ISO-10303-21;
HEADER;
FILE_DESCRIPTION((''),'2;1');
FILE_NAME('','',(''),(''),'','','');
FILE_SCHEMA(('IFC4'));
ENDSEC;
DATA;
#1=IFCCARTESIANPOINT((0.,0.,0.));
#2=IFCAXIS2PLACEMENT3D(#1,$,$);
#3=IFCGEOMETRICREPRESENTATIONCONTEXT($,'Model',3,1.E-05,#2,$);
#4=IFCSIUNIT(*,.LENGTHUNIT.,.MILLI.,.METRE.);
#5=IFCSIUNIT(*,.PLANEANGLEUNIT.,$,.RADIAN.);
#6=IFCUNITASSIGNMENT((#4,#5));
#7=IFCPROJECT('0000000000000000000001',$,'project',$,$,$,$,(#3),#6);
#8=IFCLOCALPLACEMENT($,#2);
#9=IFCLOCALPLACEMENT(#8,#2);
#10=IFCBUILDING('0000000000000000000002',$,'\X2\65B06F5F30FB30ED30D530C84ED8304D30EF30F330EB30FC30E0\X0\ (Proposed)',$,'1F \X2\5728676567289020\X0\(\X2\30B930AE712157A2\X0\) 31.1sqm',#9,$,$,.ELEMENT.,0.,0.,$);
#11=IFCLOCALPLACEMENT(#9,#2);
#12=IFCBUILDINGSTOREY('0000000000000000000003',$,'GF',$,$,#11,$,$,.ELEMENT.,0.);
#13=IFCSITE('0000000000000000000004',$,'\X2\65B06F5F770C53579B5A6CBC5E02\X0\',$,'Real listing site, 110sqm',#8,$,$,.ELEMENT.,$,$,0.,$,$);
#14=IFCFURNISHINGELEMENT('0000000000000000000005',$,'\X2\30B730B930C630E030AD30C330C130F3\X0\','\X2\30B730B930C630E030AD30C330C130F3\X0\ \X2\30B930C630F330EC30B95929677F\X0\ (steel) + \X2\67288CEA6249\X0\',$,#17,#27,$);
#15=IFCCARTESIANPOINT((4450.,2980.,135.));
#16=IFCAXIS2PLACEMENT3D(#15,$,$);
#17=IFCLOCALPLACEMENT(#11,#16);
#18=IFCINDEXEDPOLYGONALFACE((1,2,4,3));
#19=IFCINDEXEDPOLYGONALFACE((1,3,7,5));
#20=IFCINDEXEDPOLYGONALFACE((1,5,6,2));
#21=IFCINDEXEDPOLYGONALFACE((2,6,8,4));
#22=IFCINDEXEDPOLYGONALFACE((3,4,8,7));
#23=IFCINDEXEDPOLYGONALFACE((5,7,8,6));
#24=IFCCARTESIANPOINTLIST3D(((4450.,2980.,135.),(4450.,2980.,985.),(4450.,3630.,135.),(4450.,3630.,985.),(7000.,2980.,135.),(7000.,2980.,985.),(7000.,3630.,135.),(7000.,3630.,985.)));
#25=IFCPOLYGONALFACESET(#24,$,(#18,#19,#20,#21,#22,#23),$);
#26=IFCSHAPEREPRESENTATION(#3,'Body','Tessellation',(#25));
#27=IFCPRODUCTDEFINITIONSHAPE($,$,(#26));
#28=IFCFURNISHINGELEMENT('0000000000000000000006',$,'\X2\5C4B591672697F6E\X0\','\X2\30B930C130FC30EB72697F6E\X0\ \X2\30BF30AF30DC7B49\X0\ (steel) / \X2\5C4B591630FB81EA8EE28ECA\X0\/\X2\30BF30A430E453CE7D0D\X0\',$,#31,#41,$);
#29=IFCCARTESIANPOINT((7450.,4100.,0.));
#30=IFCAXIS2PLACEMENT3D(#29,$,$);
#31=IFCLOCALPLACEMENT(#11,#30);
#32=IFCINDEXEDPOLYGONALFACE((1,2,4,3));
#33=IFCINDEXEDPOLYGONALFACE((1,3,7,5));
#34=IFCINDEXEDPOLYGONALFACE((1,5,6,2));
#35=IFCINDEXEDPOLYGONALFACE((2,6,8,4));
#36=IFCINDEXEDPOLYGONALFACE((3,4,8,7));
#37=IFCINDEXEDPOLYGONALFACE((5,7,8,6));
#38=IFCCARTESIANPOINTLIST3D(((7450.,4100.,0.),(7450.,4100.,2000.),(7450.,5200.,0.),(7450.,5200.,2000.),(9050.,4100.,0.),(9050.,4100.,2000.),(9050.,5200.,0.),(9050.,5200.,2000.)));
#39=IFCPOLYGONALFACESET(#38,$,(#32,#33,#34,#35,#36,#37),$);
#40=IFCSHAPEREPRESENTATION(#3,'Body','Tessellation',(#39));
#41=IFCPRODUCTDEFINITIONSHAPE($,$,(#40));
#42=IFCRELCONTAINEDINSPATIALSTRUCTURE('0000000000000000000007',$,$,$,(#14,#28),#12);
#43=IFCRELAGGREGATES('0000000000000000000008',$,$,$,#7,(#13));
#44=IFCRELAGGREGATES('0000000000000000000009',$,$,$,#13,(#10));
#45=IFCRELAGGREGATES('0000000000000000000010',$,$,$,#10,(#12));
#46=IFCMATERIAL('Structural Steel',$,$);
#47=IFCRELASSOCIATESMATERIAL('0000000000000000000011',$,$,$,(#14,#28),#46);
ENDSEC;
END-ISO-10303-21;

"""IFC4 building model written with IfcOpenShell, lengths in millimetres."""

from ifc_helpers import new_model, si_unit, frame, frame_2d, origin, place, context, project, spatial, rectangle, extrude, material, element, save


model = new_model("IFC4")

# Units and contexts
model_context = context("Model", 3, precision=1e-05, world=origin())
ifc_project = project(units=[si_unit("LENGTHUNIT", "METRE", prefix="MILLI"), si_unit("PLANEANGLEUNIT", "RADIAN")], contexts=[model_context])

# Site, building, storey
site_placement = place(None, origin())
site = spatial("IfcSite", under=ifc_project, at=site_placement, Name="新潟県南魚沼市", ObjectType="Real listing site, 110sqm", CompositionType="ELEMENT", RefElevation=0.0)
building_placement = place(site_placement, origin())
building = spatial("IfcBuilding", under=site, at=building_placement, Name="新潟・ロフト付きワンルーム (Proposed)", ObjectType="1F 在来木造(スギ無垢) 31.1sqm", CompositionType="ELEMENT", ElevationOfRefHeight=0.0, ElevationOfTerrain=0.0)
storey_placement = place(building_placement, origin())
storey = spatial("IfcBuildingStorey", under=building, at=storey_placement, Name="GF", CompositionType="ELEMENT", Elevation=0.0)

# Shared definitions
ifc_material_1 = material(Name="Structural Steel")

# Furnishing elements
furnishing_1_placement = place(storey_placement, frame((4450.0, 2980.0, 135.0)))
element("IfcFurnishingElement", 1, at=furnishing_1_placement, inside=storey, material=ifc_material_1, Name="システムキッチン", Description="システムキッチン ステンレス天板 (steel) + 木質扉", context=model_context, shape_type="SweptSolid", body=[
    extrude(rectangle(XDim=2550.0, YDim=650.0, at=frame_2d((1275.0, 325.0))), frame((4450.0, 2980.0, 135.0)), (0.0, 0.0, 1.0), 850.0),
])
furnishing_2_placement = place(storey_placement, frame((7450.0, 4100.0, 0.0)))
element("IfcFurnishingElement", 2, at=furnishing_2_placement, inside=storey, material=ifc_material_1, Name="屋外物置", Description="スチール物置 タクボ等 (steel) / 屋外・自転車/タイヤ収納", context=model_context, shape_type="SweptSolid", body=[
    extrude(rectangle(XDim=1600.0, YDim=1100.0, at=frame_2d((800.0, 550.0))), frame((7450.0, 4100.0, 0.0)), (0.0, 0.0, 1.0), 2000.0),
])

save(model, "model.ifc")
